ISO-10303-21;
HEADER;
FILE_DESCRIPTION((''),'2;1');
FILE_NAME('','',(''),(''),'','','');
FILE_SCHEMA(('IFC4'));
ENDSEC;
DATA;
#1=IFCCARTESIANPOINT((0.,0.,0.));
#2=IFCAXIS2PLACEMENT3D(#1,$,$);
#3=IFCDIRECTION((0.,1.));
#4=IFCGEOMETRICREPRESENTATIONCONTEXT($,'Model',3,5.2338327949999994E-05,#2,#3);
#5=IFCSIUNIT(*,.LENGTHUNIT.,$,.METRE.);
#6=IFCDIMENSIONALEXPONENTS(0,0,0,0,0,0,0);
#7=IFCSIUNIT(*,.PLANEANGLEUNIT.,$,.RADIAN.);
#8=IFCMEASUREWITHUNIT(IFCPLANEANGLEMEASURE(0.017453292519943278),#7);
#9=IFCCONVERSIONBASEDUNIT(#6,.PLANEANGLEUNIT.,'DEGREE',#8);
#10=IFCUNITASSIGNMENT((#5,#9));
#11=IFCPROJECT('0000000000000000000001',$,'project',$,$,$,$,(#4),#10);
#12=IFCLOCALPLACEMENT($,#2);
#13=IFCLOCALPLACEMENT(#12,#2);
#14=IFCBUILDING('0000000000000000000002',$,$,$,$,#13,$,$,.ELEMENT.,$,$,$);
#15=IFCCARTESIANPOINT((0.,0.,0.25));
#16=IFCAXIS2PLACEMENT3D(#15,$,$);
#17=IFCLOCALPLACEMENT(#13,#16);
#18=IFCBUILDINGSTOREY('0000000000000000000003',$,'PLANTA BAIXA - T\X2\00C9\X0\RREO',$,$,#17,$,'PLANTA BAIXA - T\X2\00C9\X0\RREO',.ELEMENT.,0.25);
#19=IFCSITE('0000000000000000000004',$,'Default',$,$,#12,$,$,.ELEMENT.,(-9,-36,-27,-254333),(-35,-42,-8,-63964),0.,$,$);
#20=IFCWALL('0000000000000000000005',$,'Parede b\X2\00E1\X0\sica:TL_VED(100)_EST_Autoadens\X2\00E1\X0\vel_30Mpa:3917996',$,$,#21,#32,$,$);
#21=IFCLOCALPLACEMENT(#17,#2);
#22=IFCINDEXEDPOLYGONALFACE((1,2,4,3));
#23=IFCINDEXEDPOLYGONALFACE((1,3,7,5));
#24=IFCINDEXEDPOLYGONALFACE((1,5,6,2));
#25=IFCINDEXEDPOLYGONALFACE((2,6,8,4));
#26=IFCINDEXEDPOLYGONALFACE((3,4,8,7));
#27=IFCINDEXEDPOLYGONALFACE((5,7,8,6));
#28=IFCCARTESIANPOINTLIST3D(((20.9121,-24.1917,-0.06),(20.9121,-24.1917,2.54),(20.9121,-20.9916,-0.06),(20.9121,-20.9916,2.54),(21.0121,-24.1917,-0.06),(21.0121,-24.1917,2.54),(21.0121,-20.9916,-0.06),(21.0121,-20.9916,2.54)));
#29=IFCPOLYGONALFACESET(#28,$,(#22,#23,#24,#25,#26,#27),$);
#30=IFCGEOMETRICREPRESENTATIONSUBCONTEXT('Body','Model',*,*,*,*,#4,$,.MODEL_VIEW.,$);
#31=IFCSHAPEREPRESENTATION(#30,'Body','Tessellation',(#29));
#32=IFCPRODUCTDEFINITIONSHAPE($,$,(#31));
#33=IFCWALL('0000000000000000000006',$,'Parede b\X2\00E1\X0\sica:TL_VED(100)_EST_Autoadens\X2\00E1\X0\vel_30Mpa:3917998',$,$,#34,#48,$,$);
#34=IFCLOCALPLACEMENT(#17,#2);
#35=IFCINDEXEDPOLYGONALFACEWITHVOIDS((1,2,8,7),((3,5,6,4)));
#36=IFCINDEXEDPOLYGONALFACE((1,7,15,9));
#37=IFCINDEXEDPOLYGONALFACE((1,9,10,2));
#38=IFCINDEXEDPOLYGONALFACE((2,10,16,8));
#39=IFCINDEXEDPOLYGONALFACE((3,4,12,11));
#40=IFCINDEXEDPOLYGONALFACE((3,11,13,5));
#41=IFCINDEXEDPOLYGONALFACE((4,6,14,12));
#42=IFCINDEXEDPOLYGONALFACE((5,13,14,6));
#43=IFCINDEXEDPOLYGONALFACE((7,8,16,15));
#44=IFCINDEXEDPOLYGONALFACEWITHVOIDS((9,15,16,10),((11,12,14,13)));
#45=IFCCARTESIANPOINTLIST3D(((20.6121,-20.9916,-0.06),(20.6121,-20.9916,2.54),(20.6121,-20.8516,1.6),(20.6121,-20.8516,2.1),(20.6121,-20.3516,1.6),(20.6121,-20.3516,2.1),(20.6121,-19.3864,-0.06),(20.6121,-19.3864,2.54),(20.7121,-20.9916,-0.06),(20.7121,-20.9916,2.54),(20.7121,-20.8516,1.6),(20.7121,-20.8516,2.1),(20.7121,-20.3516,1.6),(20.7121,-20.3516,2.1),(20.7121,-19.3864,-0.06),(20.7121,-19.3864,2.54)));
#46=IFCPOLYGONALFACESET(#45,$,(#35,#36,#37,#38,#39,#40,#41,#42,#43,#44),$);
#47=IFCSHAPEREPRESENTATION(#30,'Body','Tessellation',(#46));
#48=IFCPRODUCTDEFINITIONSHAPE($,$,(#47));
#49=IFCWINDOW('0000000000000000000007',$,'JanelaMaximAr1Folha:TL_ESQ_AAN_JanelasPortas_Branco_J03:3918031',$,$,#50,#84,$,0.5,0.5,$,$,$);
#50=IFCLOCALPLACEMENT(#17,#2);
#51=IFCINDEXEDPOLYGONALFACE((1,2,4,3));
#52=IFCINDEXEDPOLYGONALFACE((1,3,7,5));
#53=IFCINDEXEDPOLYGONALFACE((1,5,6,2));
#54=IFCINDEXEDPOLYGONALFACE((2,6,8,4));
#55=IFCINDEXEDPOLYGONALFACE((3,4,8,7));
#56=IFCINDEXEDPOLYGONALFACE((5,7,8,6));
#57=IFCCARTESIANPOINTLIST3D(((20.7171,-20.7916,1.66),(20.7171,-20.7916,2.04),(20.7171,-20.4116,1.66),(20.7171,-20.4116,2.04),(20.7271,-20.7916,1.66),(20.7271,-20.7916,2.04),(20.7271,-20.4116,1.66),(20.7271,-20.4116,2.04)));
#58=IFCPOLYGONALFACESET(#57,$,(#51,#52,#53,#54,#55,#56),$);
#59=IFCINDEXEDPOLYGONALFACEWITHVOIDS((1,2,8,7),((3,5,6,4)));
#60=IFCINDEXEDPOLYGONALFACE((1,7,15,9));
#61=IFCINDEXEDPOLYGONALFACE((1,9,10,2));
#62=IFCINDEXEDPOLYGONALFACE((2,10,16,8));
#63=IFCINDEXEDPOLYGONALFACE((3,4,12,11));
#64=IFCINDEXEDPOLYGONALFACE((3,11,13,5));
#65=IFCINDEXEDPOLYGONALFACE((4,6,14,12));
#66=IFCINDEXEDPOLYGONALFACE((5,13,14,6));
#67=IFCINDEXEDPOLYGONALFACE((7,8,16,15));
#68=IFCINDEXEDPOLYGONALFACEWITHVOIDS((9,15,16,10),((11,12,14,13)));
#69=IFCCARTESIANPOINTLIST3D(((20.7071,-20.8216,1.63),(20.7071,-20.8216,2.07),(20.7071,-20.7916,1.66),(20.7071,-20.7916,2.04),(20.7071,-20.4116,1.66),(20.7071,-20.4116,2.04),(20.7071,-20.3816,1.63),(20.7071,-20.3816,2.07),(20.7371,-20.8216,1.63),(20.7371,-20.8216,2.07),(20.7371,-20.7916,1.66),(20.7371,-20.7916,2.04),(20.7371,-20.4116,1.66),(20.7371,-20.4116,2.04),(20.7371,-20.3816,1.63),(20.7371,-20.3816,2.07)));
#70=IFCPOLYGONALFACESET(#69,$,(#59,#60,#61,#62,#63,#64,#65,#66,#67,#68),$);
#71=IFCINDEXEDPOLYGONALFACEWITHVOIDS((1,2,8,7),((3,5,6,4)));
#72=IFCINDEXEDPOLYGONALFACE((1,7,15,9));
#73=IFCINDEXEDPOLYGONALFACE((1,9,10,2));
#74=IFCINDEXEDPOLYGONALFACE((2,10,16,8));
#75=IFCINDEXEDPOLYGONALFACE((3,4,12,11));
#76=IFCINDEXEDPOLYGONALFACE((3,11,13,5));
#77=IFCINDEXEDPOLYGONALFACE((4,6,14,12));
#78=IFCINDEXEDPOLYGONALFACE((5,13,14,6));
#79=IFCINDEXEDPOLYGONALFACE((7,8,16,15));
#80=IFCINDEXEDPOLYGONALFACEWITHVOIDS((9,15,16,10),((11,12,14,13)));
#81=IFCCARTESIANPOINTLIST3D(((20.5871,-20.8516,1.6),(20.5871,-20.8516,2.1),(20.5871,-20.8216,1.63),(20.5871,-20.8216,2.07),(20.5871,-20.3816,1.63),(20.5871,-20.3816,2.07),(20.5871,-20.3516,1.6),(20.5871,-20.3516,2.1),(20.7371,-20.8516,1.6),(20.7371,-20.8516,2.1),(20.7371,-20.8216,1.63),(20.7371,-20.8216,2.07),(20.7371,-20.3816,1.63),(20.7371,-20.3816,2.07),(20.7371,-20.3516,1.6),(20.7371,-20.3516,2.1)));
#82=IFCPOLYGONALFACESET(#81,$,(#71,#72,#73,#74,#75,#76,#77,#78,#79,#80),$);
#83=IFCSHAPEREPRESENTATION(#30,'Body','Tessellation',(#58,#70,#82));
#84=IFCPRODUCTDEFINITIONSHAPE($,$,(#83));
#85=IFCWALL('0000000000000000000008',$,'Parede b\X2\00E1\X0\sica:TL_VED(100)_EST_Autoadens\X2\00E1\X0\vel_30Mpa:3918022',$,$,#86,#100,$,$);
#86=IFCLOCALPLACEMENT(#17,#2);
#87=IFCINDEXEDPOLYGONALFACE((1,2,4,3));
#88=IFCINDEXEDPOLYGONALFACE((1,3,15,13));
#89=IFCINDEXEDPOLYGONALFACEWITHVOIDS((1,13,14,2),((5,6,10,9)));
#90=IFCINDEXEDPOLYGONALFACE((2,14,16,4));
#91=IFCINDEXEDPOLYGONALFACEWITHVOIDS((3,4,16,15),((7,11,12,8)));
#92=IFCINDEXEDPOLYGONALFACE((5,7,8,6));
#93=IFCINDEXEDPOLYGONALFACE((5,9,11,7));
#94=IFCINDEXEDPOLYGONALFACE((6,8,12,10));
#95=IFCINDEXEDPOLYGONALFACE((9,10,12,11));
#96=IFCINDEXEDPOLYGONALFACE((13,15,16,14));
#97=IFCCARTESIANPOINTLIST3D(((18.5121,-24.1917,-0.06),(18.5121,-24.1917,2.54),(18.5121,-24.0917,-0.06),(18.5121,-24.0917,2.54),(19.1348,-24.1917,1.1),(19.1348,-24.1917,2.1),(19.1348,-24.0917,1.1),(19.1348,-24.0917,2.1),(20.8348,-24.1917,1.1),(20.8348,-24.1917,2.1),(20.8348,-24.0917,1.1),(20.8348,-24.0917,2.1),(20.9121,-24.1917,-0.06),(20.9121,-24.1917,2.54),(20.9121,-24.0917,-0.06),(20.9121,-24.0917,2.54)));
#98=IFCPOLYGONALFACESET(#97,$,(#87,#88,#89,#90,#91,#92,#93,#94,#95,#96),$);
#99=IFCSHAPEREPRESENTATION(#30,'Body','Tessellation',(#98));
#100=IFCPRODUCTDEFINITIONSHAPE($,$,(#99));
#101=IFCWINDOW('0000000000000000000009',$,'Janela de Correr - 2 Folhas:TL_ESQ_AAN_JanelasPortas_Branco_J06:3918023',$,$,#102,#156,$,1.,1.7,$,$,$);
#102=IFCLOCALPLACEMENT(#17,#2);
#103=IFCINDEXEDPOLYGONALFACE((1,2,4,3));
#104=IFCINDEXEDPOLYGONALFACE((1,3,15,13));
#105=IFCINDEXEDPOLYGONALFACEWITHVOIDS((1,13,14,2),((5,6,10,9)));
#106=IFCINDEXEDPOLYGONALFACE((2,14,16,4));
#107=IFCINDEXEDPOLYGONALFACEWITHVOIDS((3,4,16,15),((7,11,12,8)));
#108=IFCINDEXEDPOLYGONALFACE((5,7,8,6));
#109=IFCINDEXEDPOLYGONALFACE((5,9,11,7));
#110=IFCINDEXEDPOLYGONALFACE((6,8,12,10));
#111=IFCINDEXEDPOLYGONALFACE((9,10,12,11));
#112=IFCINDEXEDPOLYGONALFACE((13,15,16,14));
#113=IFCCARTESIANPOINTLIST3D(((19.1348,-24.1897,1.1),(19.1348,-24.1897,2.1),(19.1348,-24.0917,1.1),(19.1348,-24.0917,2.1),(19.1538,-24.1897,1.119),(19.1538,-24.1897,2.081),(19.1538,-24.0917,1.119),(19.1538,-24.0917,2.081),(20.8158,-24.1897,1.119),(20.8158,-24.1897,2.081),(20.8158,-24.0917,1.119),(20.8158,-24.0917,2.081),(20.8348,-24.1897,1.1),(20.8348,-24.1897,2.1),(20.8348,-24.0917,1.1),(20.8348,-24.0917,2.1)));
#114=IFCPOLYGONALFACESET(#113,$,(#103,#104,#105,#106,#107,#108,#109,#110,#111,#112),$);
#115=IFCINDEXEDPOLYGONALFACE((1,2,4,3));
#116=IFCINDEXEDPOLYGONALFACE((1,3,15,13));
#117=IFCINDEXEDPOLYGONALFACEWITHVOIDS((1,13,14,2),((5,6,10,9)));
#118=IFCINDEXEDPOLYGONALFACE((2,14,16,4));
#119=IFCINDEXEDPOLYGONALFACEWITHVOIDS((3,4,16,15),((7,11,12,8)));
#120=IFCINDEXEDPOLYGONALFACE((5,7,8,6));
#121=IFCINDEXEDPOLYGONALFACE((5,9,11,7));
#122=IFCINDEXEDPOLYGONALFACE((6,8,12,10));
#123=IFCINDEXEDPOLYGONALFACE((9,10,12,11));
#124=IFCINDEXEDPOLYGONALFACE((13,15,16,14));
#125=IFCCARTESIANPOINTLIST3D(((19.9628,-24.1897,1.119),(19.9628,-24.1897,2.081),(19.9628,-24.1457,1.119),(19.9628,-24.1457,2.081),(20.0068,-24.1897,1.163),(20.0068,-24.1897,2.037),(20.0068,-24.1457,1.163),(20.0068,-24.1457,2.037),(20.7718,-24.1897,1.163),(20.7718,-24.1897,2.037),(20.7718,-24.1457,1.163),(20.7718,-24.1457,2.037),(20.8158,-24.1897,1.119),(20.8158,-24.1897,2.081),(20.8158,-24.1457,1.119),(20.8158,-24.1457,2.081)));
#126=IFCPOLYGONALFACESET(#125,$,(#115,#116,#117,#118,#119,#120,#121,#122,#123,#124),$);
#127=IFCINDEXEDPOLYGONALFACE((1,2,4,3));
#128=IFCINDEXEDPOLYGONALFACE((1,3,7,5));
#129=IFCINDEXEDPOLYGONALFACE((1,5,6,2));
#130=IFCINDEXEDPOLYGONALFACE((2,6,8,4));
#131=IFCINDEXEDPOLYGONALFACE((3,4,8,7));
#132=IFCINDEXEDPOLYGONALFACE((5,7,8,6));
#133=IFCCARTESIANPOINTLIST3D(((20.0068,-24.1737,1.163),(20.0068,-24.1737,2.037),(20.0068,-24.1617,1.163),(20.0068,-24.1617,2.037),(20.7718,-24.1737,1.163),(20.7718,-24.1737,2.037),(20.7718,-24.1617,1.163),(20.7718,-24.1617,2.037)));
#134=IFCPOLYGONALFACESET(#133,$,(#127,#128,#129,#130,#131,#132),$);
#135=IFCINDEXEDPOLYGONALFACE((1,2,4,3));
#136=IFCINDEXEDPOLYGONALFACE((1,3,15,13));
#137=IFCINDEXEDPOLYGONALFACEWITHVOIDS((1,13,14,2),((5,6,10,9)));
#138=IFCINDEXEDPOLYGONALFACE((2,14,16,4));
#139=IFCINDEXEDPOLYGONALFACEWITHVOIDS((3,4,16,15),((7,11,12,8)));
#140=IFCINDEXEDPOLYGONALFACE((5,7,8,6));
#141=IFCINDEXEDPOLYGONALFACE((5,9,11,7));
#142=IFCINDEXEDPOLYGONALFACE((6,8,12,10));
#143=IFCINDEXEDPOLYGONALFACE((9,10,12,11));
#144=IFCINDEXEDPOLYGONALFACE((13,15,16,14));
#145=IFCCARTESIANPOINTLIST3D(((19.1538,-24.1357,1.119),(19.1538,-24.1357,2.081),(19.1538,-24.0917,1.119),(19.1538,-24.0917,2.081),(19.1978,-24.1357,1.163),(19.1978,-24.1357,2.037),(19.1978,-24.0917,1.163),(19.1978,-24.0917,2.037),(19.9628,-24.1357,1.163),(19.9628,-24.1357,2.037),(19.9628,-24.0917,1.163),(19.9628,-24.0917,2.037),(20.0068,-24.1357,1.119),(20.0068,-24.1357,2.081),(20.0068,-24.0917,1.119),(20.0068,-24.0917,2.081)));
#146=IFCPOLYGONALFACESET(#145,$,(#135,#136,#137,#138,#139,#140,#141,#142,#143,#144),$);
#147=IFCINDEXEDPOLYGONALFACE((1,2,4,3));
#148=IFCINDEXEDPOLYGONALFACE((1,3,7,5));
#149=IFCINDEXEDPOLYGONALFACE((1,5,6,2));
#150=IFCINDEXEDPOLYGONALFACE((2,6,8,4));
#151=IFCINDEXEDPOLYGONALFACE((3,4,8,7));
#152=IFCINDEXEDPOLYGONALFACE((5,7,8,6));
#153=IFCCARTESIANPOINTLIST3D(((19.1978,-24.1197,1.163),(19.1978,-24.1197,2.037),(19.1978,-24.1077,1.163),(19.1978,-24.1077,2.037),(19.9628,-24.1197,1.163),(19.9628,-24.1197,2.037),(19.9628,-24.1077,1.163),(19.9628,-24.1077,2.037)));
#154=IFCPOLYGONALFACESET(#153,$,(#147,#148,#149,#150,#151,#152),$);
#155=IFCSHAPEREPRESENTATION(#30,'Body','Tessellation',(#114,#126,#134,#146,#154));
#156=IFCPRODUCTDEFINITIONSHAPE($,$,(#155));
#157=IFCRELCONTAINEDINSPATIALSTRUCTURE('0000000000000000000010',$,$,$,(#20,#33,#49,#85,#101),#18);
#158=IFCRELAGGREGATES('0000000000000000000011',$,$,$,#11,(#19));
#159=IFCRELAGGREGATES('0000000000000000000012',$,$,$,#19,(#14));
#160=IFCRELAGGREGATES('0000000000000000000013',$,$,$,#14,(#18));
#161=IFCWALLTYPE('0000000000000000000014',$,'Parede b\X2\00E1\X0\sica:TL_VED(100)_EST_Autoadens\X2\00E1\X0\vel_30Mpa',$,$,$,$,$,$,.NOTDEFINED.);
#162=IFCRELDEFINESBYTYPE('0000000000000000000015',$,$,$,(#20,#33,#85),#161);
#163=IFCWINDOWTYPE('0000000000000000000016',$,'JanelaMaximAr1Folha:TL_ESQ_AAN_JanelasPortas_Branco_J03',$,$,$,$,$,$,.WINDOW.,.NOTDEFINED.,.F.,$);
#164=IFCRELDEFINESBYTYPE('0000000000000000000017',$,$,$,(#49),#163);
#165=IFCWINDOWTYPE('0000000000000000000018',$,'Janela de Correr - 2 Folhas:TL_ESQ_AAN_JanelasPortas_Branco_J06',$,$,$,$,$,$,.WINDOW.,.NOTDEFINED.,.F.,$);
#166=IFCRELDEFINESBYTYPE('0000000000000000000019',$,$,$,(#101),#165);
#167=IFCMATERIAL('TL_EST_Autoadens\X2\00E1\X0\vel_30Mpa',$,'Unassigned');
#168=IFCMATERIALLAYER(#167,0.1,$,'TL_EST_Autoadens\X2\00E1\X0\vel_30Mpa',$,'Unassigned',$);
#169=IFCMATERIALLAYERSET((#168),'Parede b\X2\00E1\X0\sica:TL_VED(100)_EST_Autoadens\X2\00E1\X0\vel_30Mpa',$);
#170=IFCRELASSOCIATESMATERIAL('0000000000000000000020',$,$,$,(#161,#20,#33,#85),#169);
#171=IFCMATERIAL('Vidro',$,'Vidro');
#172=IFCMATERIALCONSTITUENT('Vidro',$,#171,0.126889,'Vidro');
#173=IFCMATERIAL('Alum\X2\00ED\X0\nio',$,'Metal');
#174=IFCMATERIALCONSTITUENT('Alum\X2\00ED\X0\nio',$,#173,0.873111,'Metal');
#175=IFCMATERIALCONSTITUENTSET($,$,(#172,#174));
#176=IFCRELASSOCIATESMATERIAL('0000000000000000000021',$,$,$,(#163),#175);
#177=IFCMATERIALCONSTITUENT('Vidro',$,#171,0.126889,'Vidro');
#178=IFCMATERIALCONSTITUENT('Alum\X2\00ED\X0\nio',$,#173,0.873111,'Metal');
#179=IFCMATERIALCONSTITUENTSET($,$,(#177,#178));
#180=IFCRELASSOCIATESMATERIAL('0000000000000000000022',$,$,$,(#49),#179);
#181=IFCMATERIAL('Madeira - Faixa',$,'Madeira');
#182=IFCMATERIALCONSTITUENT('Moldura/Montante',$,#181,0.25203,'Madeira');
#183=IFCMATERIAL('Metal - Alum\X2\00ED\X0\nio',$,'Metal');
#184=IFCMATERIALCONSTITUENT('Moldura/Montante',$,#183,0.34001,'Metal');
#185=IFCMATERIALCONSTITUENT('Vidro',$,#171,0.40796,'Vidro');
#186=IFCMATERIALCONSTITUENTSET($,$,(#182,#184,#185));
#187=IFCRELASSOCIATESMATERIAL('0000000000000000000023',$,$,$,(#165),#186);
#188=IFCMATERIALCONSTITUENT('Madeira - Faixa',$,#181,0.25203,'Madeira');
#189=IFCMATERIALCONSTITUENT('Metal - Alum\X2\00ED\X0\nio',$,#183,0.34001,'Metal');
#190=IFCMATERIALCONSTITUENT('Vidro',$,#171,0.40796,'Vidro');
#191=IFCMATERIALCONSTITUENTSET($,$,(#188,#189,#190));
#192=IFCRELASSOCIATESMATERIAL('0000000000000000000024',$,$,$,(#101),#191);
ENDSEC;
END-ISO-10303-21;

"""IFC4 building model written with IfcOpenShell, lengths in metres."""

from ifc_helpers import new_model, entity, si_unit, converted_unit, direction, frame, frame_2d, origin, origin_2d_with_axis, place, context, subcontext, project, spatial, polyline, rectangle, outline, extrude, source, transform, mapped, material, layer, layer_set, layer_usage, constituent, constituent_set, type_object, type_shapes, element, fill, save


model = new_model("IFC4")

# Units and contexts
model_context = context("Model", 3, precision=5.2338327949999994e-05, world=origin(), true_north=direction((0.0, 1.0)))
body_context = subcontext(model_context, "Body", "Model", "MODEL_VIEW")
ifc_project = project(units=[si_unit("LENGTHUNIT", "METRE"), converted_unit("PLANEANGLEUNIT", "DEGREE", entity("IfcPlaneAngleMeasure", 0.017453292519943278), si_unit("PLANEANGLEUNIT", "RADIAN"), dimensions=[0, 0, 0, 0, 0, 0, 0])], contexts=[model_context])

# Site, building, storey
site_placement = place(None, frame((0.0, 0.0, 0.0)))
site = spatial("IfcSite", under=ifc_project, at=site_placement, Name="Default", CompositionType="ELEMENT", RefLatitude=(-9, -36, -27, -254333), RefLongitude=(-35, -42, -8, -63964), RefElevation=0.0)
building_placement = place(site_placement, origin())
building = spatial("IfcBuilding", under=site, at=building_placement, CompositionType="ELEMENT")
storey_placement = place(building_placement, frame((0.0, 0.0, 0.25)))
storey = spatial("IfcBuildingStorey", under=building, at=storey_placement, Name="PLANTA BAIXA - TÉRREO", LongName="PLANTA BAIXA - TÉRREO", CompositionType="ELEMENT", Elevation=0.25)

# Wall
ifc_material_1 = material(Name="TL_EST_Autoadensável_30Mpa", Category="Unassigned")
ifc_layer_1 = layer(ifc_material_1, 0.1, Name="TL_EST_Autoadensável_30Mpa", Category="Unassigned")
ifc_layer_set_1 = layer_set([ifc_layer_1], Name="Parede básica:TL_VED(100)_EST_Autoadensável_30Mpa")
ifc_layer_usage_1 = layer_usage(ifc_layer_set_1, "AXIS2", "NEGATIVE", 0.05)
wall_type_1 = type_object("IfcWallType", Name="Parede básica:TL_VED(100)_EST_Autoadensável_30Mpa", PredefinedType="NOTDEFINED", material=ifc_layer_set_1)
wall_1_placement = place(storey_placement, frame((20.9621, -24.1917, -0.06), z_axis=(0.0, 0.0, 1.0), x_axis=(0.0, 1.0, 0.0)))
element("IfcWall", 1, at=wall_1_placement, inside=storey, type_object=wall_type_1, material=ifc_layer_usage_1, Name="Parede básica:TL_VED(100)_EST_Autoadensável_30Mpa:3917996", context=body_context, shape_type="SweptSolid", body=[
    extrude(rectangle(XDim=3.2001, YDim=0.1, at=frame_2d((1.6001, 0.0), x_axis=(-1.0, 0.0))), origin(), (0.0, 0.0, 1.0), 2.6),
])

# Walls, openings, windows
ifc_layer_usage_2 = layer_usage(ifc_layer_set_1, "AXIS2", "NEGATIVE", 0.05)
wall_2_placement = place(storey_placement, frame((20.6621, -19.3864, -0.06), z_axis=(0.0, 0.0, 1.0), x_axis=(0.0, -1.0, 0.0)))
wall_2 = element("IfcWall", 2, at=wall_2_placement, inside=storey, type_object=wall_type_1, material=ifc_layer_usage_2, Name="Parede básica:TL_VED(100)_EST_Autoadensável_30Mpa:3917998", context=body_context, shape_type="SweptSolid", body=[
    extrude(rectangle(XDim=1.6052, YDim=0.1, at=frame_2d((0.8026, 0.0), x_axis=(-1.0, 0.0))), origin(), (0.0, 0.0, 1.0), 2.6),
])
opening_1_placement = place(wall_2_placement, frame((1.4652, 0.05, 1.66)))
opening_1 = element("IfcOpeningElement", 3, at=opening_1_placement, cuts=wall_2, PredefinedType="OPENING", context=body_context, shape_type="SweptSolid", body=[
    extrude(rectangle(XDim=0.5, YDim=0.5, at=frame_2d((0.25, 0.25), x_axis=(1.0, 0.0))), frame((0.0, 0.0, 0.0), z_axis=(0.0, -1.0, 0.0), x_axis=(0.0, 0.0, 1.0)), (0.0, 0.0, 1.0), 0.1),
])
ifc_material_2 = material(Name="Vidro", Category="Vidro")
ifc_constituent_1 = constituent(ifc_material_2, Name="Vidro", Category="Vidro", fraction=0.126889)
ifc_material_3 = material(Name="Alumínio", Category="Metal")
ifc_constituent_2 = constituent(ifc_material_3, Name="Alumínio", Category="Metal", fraction=0.873111)
ifc_constituent_set_1 = constituent_set(constituents=[ifc_constituent_1, ifc_constituent_2])
ifc_constituent_3 = constituent(ifc_material_2, Name="Vidro", Category="Vidro", fraction=0.126889)
ifc_constituent_4 = constituent(ifc_material_3, Name="Alumínio", Category="Metal", fraction=0.873111)
ifc_constituent_set_2 = constituent_set(constituents=[ifc_constituent_3, ifc_constituent_4])
window_type_1 = type_object("IfcWindowType", Name="JanelaMaximAr1Folha:TL_ESQ_AAN_JanelasPortas_Branco_J03", ParameterTakesPrecedence=False, PartitioningType="NOTDEFINED", PredefinedType="WINDOW", material=ifc_constituent_set_2)
shared_shape_1 = source(origin(), body_context, "Body", "SweptSolid", [
    extrude(rectangle(XDim=0.01, YDim=0.38, at=frame_2d((0.0, 0.0), x_axis=(1.0, 0.0))), frame((0.25, -0.01, 0.06), z_axis=(0.0, 0.0, 1.0), x_axis=(0.0, 1.0, 0.0)), (0.0, 0.0, 1.0), 0.38),
    extrude(outline(polyline([(-0.22, -0.22), (0.22, -0.22), (0.22, 0.22), (-0.22, 0.22), (-0.22, -0.22)]), holes=[polyline([(0.19, 0.19), (0.19, -0.19), (-0.19, -0.19), (-0.19, 0.19), (0.19, 0.19)])]), frame((0.25, -0.025, 0.25), z_axis=(0.0, 1.0, 0.0), x_axis=(0.0, 0.0, -1.0)), (0.0, 0.0, 1.0), 0.03),
    extrude(outline(polyline([(-0.25, -0.25), (0.25, -0.25), (0.25, 0.25), (-0.25, 0.25), (-0.25, -0.25)]), holes=[polyline([(-0.22, -0.22), (-0.22, 0.22), (0.22, 0.22), (0.22, -0.22), (-0.22, -0.22)])]), frame((0.25, -0.025, 0.25), z_axis=(0.0, 1.0, 0.0), x_axis=(0.0, 0.0, -1.0)), (0.0, 0.0, 1.0), 0.15),
])
type_shapes(window_type_1, [shared_shape_1])
window_1_placement = place(opening_1_placement, frame((0.0, 0.0, 0.0), z_axis=(0.0, 0.0, 1.0), x_axis=(-1.0, 0.0, 0.0)))
window_1 = element("IfcWindow", 4, at=window_1_placement, inside=storey, type_object=window_type_1, material=ifc_constituent_set_1, Name="JanelaMaximAr1Folha:TL_ESQ_AAN_JanelasPortas_Branco_J03:3918031", OverallHeight=0.5, OverallWidth=0.5, context=body_context, shape_type="MappedRepresentation", body=[
    mapped(shared_shape_1, transform((0.0, 0.0, 0.0), scale=1.0)),
])
fill(opening_1, window_1)
ifc_layer_usage_3 = layer_usage(ifc_layer_set_1, "AXIS2", "NEGATIVE", 0.05)
wall_3_placement = place(storey_placement, frame((20.9121, -24.1417, -0.06), z_axis=(0.0, 0.0, 1.0), x_axis=(-1.0, 0.0, 0.0)))
wall_3 = element("IfcWall", 5, at=wall_3_placement, inside=storey, type_object=wall_type_1, material=ifc_layer_usage_3, Name="Parede básica:TL_VED(100)_EST_Autoadensável_30Mpa:3918022", context=body_context, shape_type="SweptSolid", body=[
    extrude(rectangle(XDim=2.4, YDim=0.1, at=frame_2d((1.2, 0.0), x_axis=(-1.0, 0.0))), origin(), (0.0, 0.0, 1.0), 2.6),
])
opening_2_placement = place(wall_3_placement, frame((0.0774, -0.05, 1.16)))
opening_2 = element("IfcOpeningElement", 6, at=opening_2_placement, cuts=wall_3, PredefinedType="OPENING", context=body_context, shape_type="SweptSolid", body=[
    extrude(rectangle(XDim=1.0, YDim=1.7, at=frame_2d((0.5, 0.85), x_axis=(-1.0, 0.0))), frame((0.0, 0.0, 0.0), z_axis=(0.0, 1.0, 0.0), x_axis=(0.0, 0.0, 1.0)), (0.0, 0.0, 1.0), 0.1),
])
ifc_material_4 = material(Name="Madeira - Faixa", Category="Madeira")
ifc_constituent_5 = constituent(ifc_material_4, Name="Madeira - Faixa", Category="Madeira", fraction=0.25203)
ifc_material_5 = material(Name="Metal - Alumínio", Category="Metal")
ifc_constituent_6 = constituent(ifc_material_5, Name="Metal - Alumínio", Category="Metal", fraction=0.34001)
ifc_constituent_7 = constituent(ifc_material_2, Name="Vidro", Category="Vidro", fraction=0.40796)
ifc_constituent_set_3 = constituent_set(constituents=[ifc_constituent_5, ifc_constituent_6, ifc_constituent_7])
ifc_constituent_8 = constituent(ifc_material_4, Name="Moldura/Montante", Category="Madeira", fraction=0.25203)
ifc_constituent_9 = constituent(ifc_material_5, Name="Moldura/Montante", Category="Metal", fraction=0.34001)
ifc_constituent_10 = constituent(ifc_material_2, Name="Vidro", Category="Vidro", fraction=0.40796)
ifc_constituent_set_4 = constituent_set(constituents=[ifc_constituent_8, ifc_constituent_9, ifc_constituent_10])
window_type_2 = type_object("IfcWindowType", Name="Janela de Correr - 2 Folhas:TL_ESQ_AAN_JanelasPortas_Branco_J06", ParameterTakesPrecedence=False, PartitioningType="NOTDEFINED", PredefinedType="WINDOW", material=ifc_constituent_set_4)
shared_shape_2 = source(origin(), body_context, "Body", "SweptSolid", [
    extrude(outline(polyline([(-0.85, -0.5), (0.85, -0.5), (0.85, 0.5), (-0.85, 0.5), (-0.85, -0.5)]), holes=[polyline([(-0.831, -0.481), (-0.831, 0.481), (0.831, 0.481), (0.831, -0.481), (-0.831, -0.481)])]), frame((0.85, 0.124, 0.5), z_axis=(0.0, -1.0, 0.0), x_axis=(-1.0, 0.0, 0.0)), (0.0, 0.0, 1.0), 0.098),
    extrude(outline(polyline([(-0.4265, -0.481), (0.4265, -0.481), (0.4265, 0.481), (-0.4265, 0.481), (-0.4265, -0.481)]), holes=[polyline([(-0.3825, -0.437), (-0.3825, 0.437), (0.3825, 0.437), (0.3825, -0.437), (-0.3825, -0.437)])]), frame((0.4455, 0.124, 0.5), z_axis=(0.0, -1.0, 0.0), x_axis=(-1.0, 0.0, 0.0)), (0.0, 0.0, 1.0), 0.044),
    extrude(rectangle(XDim=0.765, YDim=0.012, at=origin_2d_with_axis()), frame((0.4455, 0.102, 0.063), z_axis=(0.0, 0.0, 1.0), x_axis=(-1.0, 0.0, 0.0)), (0.0, 0.0, 1.0), 0.874),
    extrude(outline(polyline([(-0.481, -0.4265), (0.481, -0.4265), (0.481, 0.4265), (-0.481, 0.4265), (-0.481, -0.4265)]), holes=[polyline([(-0.437, -0.3825), (-0.437, 0.3825), (0.437, 0.3825), (0.437, -0.3825), (-0.437, -0.3825)])]), frame((1.2545, 0.07, 0.5), z_axis=(0.0, -1.0, 0.0), x_axis=(0.0, 0.0, -1.0)), (0.0, 0.0, 1.0), 0.044),
    extrude(rectangle(XDim=0.765, YDim=0.012, at=origin_2d_with_axis()), frame((1.2545, 0.048, 0.063), z_axis=(0.0, 0.0, 1.0), x_axis=(-1.0, 0.0, 0.0)), (0.0, 0.0, 1.0), 0.874),
])
type_shapes(window_type_2, [shared_shape_2])
window_2_placement = place(opening_2_placement, frame((0.0, -0.026, 0.0)))
window_2 = element("IfcWindow", 7, at=window_2_placement, inside=storey, type_object=window_type_2, material=ifc_constituent_set_3, Name="Janela de Correr - 2 Folhas:TL_ESQ_AAN_JanelasPortas_Branco_J06:3918023", OverallHeight=1.0, OverallWidth=1.7, context=body_context, shape_type="MappedRepresentation", body=[
    mapped(shared_shape_2, transform((0.0, 0.0, 0.0), scale=1.0)),
])
fill(opening_2, window_2)

save(model, "model.ifc")
